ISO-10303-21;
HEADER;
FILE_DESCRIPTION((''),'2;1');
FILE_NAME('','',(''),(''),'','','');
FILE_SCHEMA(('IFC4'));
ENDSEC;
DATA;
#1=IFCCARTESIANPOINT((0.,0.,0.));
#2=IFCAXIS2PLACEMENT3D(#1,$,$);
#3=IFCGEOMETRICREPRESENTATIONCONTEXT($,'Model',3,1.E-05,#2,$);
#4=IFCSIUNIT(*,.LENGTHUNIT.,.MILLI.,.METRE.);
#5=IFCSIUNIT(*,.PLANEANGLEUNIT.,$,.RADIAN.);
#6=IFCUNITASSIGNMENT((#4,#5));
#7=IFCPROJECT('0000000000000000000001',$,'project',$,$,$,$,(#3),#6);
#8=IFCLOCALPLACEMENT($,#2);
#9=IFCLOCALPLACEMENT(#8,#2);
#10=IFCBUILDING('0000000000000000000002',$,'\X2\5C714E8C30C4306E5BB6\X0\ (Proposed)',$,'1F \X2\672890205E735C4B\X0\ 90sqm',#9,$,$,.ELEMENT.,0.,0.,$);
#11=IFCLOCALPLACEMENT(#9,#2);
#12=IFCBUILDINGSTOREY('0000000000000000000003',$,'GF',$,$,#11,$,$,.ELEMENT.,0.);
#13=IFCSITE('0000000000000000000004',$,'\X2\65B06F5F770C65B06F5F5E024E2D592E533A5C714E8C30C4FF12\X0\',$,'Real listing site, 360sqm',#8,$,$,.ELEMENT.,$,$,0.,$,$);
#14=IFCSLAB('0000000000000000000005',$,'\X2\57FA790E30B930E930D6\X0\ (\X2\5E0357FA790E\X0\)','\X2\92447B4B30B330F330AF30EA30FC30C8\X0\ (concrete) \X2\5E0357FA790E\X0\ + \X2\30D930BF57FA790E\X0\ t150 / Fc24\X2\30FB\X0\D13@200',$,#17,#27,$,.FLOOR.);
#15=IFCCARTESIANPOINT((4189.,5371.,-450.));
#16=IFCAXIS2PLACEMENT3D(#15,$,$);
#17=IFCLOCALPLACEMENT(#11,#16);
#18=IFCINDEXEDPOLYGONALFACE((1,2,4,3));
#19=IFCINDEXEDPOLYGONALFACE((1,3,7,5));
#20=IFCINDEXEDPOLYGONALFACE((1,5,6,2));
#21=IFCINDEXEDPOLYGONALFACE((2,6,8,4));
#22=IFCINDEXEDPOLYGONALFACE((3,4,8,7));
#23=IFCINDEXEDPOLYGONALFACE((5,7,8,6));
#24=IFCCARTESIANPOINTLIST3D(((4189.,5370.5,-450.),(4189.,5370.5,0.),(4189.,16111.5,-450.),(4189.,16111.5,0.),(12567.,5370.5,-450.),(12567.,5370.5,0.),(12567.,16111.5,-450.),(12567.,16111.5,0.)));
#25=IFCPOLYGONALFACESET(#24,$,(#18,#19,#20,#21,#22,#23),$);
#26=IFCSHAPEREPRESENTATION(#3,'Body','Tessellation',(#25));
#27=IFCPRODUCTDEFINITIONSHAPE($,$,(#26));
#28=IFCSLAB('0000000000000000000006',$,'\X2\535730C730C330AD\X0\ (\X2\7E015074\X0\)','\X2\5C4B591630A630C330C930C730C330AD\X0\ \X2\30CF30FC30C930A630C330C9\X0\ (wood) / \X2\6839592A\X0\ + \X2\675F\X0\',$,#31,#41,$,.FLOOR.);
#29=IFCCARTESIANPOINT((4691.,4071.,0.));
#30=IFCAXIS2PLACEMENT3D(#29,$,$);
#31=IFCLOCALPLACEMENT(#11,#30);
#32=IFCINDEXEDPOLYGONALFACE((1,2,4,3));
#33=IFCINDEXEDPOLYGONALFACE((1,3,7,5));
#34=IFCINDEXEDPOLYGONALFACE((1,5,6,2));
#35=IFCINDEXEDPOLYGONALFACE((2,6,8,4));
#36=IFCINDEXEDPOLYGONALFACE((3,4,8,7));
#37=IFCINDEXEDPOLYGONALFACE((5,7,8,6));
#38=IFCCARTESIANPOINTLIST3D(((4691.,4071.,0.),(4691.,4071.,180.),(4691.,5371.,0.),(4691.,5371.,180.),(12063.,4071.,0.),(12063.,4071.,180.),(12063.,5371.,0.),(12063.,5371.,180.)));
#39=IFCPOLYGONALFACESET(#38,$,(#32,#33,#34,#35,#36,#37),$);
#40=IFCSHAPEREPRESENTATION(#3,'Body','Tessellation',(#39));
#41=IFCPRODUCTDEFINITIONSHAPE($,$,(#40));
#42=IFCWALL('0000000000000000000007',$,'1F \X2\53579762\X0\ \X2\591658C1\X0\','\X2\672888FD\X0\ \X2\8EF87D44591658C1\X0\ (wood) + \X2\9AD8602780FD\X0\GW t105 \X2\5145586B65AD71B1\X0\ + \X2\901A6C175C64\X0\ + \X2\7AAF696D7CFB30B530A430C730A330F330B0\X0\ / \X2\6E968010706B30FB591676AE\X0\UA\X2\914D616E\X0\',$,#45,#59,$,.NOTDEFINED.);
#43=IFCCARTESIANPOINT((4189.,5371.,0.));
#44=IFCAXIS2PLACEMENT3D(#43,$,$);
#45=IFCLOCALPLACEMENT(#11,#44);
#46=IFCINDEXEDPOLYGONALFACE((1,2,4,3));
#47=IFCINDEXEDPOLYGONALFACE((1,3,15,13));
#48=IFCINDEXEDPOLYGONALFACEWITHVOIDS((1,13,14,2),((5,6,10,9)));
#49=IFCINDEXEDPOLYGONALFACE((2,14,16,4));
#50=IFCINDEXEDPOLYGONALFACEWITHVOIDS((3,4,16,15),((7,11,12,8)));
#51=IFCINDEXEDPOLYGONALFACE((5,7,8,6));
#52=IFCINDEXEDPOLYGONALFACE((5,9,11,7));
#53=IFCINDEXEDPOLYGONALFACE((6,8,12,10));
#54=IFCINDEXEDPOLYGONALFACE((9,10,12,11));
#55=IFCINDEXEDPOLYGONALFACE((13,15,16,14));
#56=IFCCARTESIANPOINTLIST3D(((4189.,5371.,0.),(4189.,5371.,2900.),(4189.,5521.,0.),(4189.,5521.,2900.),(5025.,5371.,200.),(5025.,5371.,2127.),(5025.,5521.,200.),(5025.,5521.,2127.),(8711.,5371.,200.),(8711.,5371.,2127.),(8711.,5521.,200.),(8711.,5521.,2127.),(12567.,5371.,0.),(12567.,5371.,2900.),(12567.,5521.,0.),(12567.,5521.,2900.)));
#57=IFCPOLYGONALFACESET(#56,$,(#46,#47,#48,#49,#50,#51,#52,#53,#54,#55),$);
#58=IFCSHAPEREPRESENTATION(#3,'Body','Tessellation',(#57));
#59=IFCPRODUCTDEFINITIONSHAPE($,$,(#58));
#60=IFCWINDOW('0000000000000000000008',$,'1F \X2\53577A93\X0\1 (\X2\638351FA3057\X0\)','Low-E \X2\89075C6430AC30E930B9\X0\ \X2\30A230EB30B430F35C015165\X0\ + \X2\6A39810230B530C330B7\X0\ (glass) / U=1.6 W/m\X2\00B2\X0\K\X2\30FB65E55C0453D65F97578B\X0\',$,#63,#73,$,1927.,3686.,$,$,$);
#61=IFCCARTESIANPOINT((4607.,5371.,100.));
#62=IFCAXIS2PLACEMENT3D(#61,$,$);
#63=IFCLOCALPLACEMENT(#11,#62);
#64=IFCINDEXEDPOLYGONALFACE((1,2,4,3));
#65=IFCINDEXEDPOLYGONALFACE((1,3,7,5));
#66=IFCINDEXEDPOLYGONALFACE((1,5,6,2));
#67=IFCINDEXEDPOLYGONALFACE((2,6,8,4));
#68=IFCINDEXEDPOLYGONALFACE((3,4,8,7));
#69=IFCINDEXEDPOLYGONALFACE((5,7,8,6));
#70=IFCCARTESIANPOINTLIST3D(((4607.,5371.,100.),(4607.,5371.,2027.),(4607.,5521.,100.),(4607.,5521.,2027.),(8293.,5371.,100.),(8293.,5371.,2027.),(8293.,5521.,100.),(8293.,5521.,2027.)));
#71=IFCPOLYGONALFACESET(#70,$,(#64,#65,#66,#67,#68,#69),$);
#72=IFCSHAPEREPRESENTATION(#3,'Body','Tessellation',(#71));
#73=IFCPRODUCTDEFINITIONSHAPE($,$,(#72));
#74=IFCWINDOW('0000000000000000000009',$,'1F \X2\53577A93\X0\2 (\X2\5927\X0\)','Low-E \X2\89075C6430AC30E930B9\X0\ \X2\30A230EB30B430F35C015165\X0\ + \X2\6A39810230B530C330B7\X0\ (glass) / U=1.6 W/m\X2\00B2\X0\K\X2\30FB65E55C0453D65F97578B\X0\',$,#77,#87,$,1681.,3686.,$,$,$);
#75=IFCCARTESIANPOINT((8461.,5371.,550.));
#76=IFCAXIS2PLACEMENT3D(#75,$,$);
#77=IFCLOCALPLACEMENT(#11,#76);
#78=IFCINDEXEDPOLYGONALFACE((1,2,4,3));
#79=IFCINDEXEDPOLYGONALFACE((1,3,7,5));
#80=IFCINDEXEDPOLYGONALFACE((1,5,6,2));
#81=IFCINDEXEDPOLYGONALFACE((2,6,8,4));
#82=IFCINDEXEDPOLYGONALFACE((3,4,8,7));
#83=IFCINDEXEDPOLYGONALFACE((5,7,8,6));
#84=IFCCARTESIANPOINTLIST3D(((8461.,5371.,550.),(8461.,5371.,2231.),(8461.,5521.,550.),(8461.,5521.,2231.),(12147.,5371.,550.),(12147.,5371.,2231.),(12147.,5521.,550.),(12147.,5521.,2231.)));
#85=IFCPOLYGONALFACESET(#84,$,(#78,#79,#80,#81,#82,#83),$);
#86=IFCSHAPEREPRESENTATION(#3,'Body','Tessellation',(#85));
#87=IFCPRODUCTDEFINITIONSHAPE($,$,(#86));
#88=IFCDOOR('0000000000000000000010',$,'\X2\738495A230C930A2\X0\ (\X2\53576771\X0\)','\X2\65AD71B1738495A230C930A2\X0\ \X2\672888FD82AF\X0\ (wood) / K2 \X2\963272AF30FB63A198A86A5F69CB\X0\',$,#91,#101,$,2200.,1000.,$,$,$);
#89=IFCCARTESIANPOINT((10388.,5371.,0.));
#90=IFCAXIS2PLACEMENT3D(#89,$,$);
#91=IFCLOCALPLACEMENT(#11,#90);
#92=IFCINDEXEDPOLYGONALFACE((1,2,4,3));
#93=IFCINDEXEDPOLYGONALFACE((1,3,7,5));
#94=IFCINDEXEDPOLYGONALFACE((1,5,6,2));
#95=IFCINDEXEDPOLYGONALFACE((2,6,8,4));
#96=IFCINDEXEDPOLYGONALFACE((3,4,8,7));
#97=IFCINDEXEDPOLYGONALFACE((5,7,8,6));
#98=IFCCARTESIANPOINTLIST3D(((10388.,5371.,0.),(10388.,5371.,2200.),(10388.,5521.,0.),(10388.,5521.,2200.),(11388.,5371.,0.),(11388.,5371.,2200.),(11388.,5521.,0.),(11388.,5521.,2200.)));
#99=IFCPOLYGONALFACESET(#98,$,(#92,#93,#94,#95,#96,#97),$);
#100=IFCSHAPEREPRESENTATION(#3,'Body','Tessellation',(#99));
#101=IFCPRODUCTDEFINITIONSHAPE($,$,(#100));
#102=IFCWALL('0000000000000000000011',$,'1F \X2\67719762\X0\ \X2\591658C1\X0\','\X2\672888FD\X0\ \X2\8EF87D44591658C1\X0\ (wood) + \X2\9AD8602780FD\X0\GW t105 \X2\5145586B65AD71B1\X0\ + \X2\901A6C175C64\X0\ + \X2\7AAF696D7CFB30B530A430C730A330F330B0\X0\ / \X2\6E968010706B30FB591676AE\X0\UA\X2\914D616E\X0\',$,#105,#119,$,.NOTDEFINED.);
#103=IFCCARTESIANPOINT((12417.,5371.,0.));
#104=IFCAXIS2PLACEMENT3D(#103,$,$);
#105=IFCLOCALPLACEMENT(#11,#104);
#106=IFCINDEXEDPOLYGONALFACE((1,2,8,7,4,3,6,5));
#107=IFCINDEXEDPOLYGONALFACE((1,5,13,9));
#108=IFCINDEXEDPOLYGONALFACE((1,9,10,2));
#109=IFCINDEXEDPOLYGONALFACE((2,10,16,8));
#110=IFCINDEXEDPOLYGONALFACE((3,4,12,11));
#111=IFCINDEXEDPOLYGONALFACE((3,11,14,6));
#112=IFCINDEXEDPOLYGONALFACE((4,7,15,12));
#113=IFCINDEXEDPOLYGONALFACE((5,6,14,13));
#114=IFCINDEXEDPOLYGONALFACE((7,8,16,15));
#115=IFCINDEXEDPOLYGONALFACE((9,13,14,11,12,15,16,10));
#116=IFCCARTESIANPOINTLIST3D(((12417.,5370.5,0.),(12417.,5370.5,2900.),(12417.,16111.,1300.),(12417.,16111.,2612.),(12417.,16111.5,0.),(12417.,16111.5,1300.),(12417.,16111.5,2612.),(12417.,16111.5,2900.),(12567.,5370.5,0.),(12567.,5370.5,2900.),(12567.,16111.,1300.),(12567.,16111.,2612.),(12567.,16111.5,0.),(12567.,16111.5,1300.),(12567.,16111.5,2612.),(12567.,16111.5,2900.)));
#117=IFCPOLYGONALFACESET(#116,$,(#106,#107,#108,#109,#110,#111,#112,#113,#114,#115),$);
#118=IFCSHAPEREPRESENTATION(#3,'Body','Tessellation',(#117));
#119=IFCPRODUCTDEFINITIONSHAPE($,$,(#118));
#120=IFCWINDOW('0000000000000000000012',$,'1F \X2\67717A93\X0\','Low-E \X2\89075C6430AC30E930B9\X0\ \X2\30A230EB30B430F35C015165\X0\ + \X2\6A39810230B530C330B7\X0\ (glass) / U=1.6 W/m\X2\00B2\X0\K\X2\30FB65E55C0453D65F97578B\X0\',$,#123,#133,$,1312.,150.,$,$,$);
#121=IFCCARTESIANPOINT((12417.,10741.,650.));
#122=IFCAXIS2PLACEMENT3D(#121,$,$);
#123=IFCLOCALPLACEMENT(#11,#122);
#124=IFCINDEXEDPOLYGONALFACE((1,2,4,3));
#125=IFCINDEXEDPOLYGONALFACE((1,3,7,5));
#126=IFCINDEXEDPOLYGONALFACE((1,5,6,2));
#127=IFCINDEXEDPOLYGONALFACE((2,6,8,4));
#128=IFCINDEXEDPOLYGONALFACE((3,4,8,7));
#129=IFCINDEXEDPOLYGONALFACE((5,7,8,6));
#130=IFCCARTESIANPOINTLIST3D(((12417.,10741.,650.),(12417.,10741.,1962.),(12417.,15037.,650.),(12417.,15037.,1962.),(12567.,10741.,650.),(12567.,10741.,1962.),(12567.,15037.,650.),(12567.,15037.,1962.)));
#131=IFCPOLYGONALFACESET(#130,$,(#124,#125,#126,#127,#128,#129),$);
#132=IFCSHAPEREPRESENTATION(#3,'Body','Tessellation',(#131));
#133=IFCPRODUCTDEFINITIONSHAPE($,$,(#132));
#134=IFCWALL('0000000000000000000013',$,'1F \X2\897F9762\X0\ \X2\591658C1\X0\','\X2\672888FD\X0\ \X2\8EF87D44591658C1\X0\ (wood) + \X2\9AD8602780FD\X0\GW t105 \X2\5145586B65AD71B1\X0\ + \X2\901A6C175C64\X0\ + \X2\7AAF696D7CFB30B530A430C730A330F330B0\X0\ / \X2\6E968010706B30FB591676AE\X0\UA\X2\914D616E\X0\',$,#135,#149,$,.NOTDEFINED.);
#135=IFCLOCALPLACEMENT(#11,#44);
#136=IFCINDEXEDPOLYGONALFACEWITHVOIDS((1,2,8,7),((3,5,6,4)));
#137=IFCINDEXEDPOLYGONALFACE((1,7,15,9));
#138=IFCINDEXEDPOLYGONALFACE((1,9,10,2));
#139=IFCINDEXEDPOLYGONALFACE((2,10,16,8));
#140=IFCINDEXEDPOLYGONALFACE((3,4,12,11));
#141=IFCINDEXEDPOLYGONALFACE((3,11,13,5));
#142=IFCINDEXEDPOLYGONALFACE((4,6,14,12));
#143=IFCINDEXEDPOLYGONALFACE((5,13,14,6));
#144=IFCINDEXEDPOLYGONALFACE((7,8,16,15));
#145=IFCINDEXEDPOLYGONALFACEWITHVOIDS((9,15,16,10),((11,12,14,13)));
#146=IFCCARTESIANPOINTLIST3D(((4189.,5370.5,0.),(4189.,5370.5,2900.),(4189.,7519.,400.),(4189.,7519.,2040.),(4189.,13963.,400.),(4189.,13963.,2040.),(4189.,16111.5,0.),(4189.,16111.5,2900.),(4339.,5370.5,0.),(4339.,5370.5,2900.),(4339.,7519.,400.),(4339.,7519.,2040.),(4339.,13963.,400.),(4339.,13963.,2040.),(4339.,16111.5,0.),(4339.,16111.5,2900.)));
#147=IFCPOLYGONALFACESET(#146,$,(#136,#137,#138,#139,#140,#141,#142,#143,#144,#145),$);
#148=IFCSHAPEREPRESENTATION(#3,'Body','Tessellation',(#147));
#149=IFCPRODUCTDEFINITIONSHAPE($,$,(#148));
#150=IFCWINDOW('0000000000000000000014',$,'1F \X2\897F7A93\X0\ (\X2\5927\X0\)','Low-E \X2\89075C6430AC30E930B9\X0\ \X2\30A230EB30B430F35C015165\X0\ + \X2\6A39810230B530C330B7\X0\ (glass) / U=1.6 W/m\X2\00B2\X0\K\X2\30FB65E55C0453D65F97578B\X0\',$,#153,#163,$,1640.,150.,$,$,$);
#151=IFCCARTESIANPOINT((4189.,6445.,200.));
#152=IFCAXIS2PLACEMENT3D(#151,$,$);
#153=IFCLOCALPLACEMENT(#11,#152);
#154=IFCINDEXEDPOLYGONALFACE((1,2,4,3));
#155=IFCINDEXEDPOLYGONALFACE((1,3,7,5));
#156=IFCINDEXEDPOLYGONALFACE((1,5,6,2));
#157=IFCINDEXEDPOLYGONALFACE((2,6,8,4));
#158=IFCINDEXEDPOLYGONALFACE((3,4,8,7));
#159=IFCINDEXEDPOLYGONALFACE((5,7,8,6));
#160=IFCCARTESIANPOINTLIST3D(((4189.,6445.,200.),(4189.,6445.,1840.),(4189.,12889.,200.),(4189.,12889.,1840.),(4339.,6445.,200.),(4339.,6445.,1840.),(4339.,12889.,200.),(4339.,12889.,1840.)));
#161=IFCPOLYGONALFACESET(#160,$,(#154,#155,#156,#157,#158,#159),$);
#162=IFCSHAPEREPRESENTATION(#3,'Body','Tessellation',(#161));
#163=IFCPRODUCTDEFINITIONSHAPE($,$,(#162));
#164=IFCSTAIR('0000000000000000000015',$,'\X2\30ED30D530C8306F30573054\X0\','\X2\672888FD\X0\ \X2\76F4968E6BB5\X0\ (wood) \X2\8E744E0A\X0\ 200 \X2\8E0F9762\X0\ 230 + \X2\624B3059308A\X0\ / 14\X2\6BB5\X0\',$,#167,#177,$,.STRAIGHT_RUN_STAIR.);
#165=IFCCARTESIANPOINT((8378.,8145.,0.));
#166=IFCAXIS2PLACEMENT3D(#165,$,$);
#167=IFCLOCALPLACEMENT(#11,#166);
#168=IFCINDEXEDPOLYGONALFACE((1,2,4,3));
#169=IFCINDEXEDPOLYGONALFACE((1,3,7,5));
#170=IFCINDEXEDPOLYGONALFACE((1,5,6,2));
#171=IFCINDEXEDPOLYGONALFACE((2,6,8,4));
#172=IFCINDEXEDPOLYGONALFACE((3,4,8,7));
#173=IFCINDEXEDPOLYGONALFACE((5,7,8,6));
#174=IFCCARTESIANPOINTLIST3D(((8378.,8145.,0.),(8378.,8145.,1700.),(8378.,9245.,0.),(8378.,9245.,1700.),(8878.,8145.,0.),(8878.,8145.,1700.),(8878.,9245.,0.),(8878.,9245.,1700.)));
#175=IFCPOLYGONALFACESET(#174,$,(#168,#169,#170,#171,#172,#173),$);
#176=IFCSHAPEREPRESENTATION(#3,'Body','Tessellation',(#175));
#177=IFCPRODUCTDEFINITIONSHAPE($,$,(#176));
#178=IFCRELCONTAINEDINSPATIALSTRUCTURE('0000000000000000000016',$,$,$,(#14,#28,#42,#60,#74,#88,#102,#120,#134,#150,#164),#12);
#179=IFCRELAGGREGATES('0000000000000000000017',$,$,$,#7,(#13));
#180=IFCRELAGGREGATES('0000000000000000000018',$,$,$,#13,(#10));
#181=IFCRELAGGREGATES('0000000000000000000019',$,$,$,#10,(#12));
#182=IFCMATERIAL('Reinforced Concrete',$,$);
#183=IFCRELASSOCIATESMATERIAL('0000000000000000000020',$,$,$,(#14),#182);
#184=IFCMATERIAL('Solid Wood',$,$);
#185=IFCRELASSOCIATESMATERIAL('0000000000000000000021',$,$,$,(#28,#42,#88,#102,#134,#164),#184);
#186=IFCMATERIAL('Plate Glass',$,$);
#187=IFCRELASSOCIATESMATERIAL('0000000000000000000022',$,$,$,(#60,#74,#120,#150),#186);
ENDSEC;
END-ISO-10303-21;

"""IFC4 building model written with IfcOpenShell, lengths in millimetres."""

from ifc_helpers import new_model, si_unit, frame, frame_2d, origin, place, context, project, spatial, rectangle, extrude, material, element, fill, save


model = new_model("IFC4")

# Units and contexts
model_context = context("Model", 3, precision=1e-05, world=origin())
ifc_project = project(units=[si_unit("LENGTHUNIT", "METRE", prefix="MILLI"), si_unit("PLANEANGLEUNIT", "RADIAN")], contexts=[model_context])

# Site, building, storey
site_placement = place(None, origin())
site = spatial("IfcSite", under=ifc_project, at=site_placement, Name="新潟県新潟市中央区山二ツ２", ObjectType="Real listing site, 360sqm", CompositionType="ELEMENT", RefElevation=0.0)
building_placement = place(site_placement, origin())
building = spatial("IfcBuilding", under=site, at=building_placement, Name="山二ツの家 (Proposed)", ObjectType="1F 木造平屋 90sqm", CompositionType="ELEMENT", ElevationOfRefHeight=0.0, ElevationOfTerrain=0.0)
storey_placement = place(building_placement, origin())
storey = spatial("IfcBuildingStorey", under=building, at=storey_placement, Name="GF", CompositionType="ELEMENT", Elevation=0.0)

# Slabs
ifc_material_1 = material(Name="Reinforced Concrete")
slab_1_placement = place(storey_placement, frame((4189.0, 5371.0, -450.0)))
element("IfcSlab", 1, at=slab_1_placement, inside=storey, material=ifc_material_1, Name="基礎スラブ (布基礎)", Description="鉄筋コンクリート (concrete) 布基礎 + ベタ基礎 t150 / Fc24・D13@200", PredefinedType="FLOOR", context=model_context, shape_type="SweptSolid", body=[
    extrude(rectangle(XDim=8378.0, YDim=10741.0, at=frame_2d((4189.0, 5370.0))), frame((4189.0, 5371.0, -450.0)), (0.0, 0.0, 1.0), 450.0),
])
ifc_material_2 = material(Name="Solid Wood")
slab_2_placement = place(storey_placement, frame((4691.0, 4071.0, 0.0)))
element("IfcSlab", 2, at=slab_2_placement, inside=storey, material=ifc_material_2, Name="南デッキ (縁側)", Description="屋外ウッドデッキ ハードウッド (wood) / 根太 + 束", PredefinedType="FLOOR", context=model_context, shape_type="SweptSolid", body=[
    extrude(rectangle(XDim=7372.0, YDim=1300.0, at=frame_2d((3686.0, 650.0))), frame((4691.0, 4071.0, 0.0)), (0.0, 0.0, 1.0), 180.0),
])

# Wall, openings, windows, door
wall_1_placement = place(storey_placement, frame((4189.0, 5371.0, 0.0)))
wall_1 = element("IfcWall", 3, at=wall_1_placement, inside=storey, material=ifc_material_2, Name="1F 南面 外壁", Description="木製 軸組外壁 (wood) + 高性能GW t105 充填断熱 + 通気層 + 窯業系サイディング / 準耐火・外皮UA配慮", PredefinedType="NOTDEFINED", context=model_context, shape_type="SweptSolid", body=[
    extrude(rectangle(XDim=8378.0, YDim=150.0, at=frame_2d((4189.0, 75.0))), frame((4189.0, 5371.0, 0.0)), (0.0, 0.0, 1.0), 2900.0),
])
opening_1_placement = place(storey_placement, frame((4607.0, 5371.0, 100.0)))
opening_1 = element("IfcOpeningElement", 4, at=opening_1_placement, cuts=wall_1, PredefinedType="NOTDEFINED", context=model_context, shape_type="SweptSolid", body=[
    extrude(rectangle(XDim=3686.0, YDim=150.0, at=frame_2d((1843.0, 75.0))), frame((4607.0, 5371.0, 100.0)), (0.0, 0.0, 1.0), 1927.0),
])
opening_2_placement = place(storey_placement, frame((8461.0, 5371.0, 550.0)))
opening_2 = element("IfcOpeningElement", 5, at=opening_2_placement, cuts=wall_1, PredefinedType="NOTDEFINED", context=model_context, shape_type="SweptSolid", body=[
    extrude(rectangle(XDim=3686.0, YDim=150.0, at=frame_2d((1843.0, 75.0))), frame((8461.0, 5371.0, 550.0)), (0.0, 0.0, 1.0), 1681.0),
])
opening_3_placement = place(storey_placement, frame((10388.0, 5371.0, 0.0)))
opening_3 = element("IfcOpeningElement", 6, at=opening_3_placement, cuts=wall_1, PredefinedType="NOTDEFINED", context=model_context, shape_type="SweptSolid", body=[
    extrude(rectangle(XDim=1000.0, YDim=150.0, at=frame_2d((500.0, 75.0))), frame((10388.0, 5371.0, 0.0)), (0.0, 0.0, 1.0), 2200.0),
])
ifc_material_3 = material(Name="Plate Glass")
window_1_placement = place(storey_placement, frame((4607.0, 5371.0, 100.0)))
window_1 = element("IfcWindow", 7, at=window_1_placement, inside=storey, material=ifc_material_3, Name="1F 南窓1 (掃出し)", Description="Low-E 複層ガラス アルゴン封入 + 樹脂サッシ (glass) / U=1.6 W/m²K・日射取得型", OverallHeight=1927.0, OverallWidth=3686.0, context=model_context, shape_type="SweptSolid", body=[
    extrude(rectangle(XDim=3686.0, YDim=150.0, at=frame_2d((1843.0, 75.0))), frame((4607.0, 5371.0, 100.0)), (0.0, 0.0, 1.0), 1927.0),
])
fill(opening_1, window_1)
window_2_placement = place(storey_placement, frame((8461.0, 5371.0, 550.0)))
window_2 = element("IfcWindow", 8, at=window_2_placement, inside=storey, material=ifc_material_3, Name="1F 南窓2 (大)", Description="Low-E 複層ガラス アルゴン封入 + 樹脂サッシ (glass) / U=1.6 W/m²K・日射取得型", OverallHeight=1681.0, OverallWidth=3686.0, context=model_context, shape_type="SweptSolid", body=[
    extrude(rectangle(XDim=3686.0, YDim=150.0, at=frame_2d((1843.0, 75.0))), frame((8461.0, 5371.0, 550.0)), (0.0, 0.0, 1.0), 1681.0),
])
fill(opening_2, window_2)
door_placement = place(storey_placement, frame((10388.0, 5371.0, 0.0)))
door = element("IfcDoor", 9, at=door_placement, inside=storey, material=ifc_material_2, Name="玄関ドア (南東)", Description="断熱玄関ドア 木製芯 (wood) / K2 防犯・採風機構", OverallHeight=2200.0, OverallWidth=1000.0, context=model_context, shape_type="SweptSolid", body=[
    extrude(rectangle(XDim=1000.0, YDim=150.0, at=frame_2d((500.0, 75.0))), frame((10388.0, 5371.0, 0.0)), (0.0, 0.0, 1.0), 2200.0),
])
fill(opening_3, door)

# Walls, openings, windows
wall_2_placement = place(storey_placement, frame((12417.0, 5371.0, 0.0)))
wall_2 = element("IfcWall", 10, at=wall_2_placement, inside=storey, material=ifc_material_2, Name="1F 東面 外壁", Description="木製 軸組外壁 (wood) + 高性能GW t105 充填断熱 + 通気層 + 窯業系サイディング / 準耐火・外皮UA配慮", PredefinedType="NOTDEFINED", context=model_context, shape_type="SweptSolid", body=[
    extrude(rectangle(XDim=150.0, YDim=10741.0, at=frame_2d((75.0, 5370.0))), frame((12417.0, 5371.0, 0.0)), (0.0, 0.0, 1.0), 2900.0),
])
opening_4_placement = place(storey_placement, frame((12417.0, 10741.0, 650.0)))
opening_4 = element("IfcOpeningElement", 11, at=opening_4_placement, cuts=wall_2, PredefinedType="NOTDEFINED", context=model_context, shape_type="SweptSolid", body=[
    extrude(rectangle(XDim=150.0, YDim=4296.0, at=frame_2d((75.0, 2148.0))), frame((12417.0, 10741.0, 650.0)), (0.0, 0.0, 1.0), 1312.0),
])
window_3_placement = place(storey_placement, frame((12417.0, 10741.0, 650.0)))
window_3 = element("IfcWindow", 12, at=window_3_placement, inside=storey, material=ifc_material_3, Name="1F 東窓", Description="Low-E 複層ガラス アルゴン封入 + 樹脂サッシ (glass) / U=1.6 W/m²K・日射取得型", OverallHeight=1312.0, OverallWidth=150.0, context=model_context, shape_type="SweptSolid", body=[
    extrude(rectangle(XDim=150.0, YDim=4296.0, at=frame_2d((75.0, 2148.0))), frame((12417.0, 10741.0, 650.0)), (0.0, 0.0, 1.0), 1312.0),
])
fill(opening_4, window_3)
wall_3_placement = place(storey_placement, frame((4189.0, 5371.0, 0.0)))
wall_3 = element("IfcWall", 13, at=wall_3_placement, inside=storey, material=ifc_material_2, Name="1F 西面 外壁", Description="木製 軸組外壁 (wood) + 高性能GW t105 充填断熱 + 通気層 + 窯業系サイディング / 準耐火・外皮UA配慮", PredefinedType="NOTDEFINED", context=model_context, shape_type="SweptSolid", body=[
    extrude(rectangle(XDim=150.0, YDim=10741.0, at=frame_2d((75.0, 5370.0))), frame((4189.0, 5371.0, 0.0)), (0.0, 0.0, 1.0), 2900.0),
])
opening_5_placement = place(storey_placement, frame((4189.0, 6445.0, 200.0)))
opening_5 = element("IfcOpeningElement", 14, at=opening_5_placement, cuts=wall_3, PredefinedType="NOTDEFINED", context=model_context, shape_type="SweptSolid", body=[
    extrude(rectangle(XDim=150.0, YDim=6444.0, at=frame_2d((75.0, 3222.0))), frame((4189.0, 6445.0, 200.0)), (0.0, 0.0, 1.0), 1640.0),
])
window_4_placement = place(storey_placement, frame((4189.0, 6445.0, 200.0)))
window_4 = element("IfcWindow", 15, at=window_4_placement, inside=storey, material=ifc_material_3, Name="1F 西窓 (大)", Description="Low-E 複層ガラス アルゴン封入 + 樹脂サッシ (glass) / U=1.6 W/m²K・日射取得型", OverallHeight=1640.0, OverallWidth=150.0, context=model_context, shape_type="SweptSolid", body=[
    extrude(rectangle(XDim=150.0, YDim=6444.0, at=frame_2d((75.0, 3222.0))), frame((4189.0, 6445.0, 200.0)), (0.0, 0.0, 1.0), 1640.0),
])
fill(opening_5, window_4)

# Stair
stair_placement = place(storey_placement, frame((8378.0, 8145.0, 0.0)))
element("IfcStair", 16, at=stair_placement, inside=storey, material=ifc_material_2, Name="ロフトはしご", Description="木製 直階段 (wood) 蹴上 200 踏面 230 + 手すり / 14段", PredefinedType="STRAIGHT_RUN_STAIR", context=model_context, shape_type="SweptSolid", body=[
    extrude(rectangle(XDim=500.0, YDim=1100.0, at=frame_2d((250.0, 550.0))), frame((8378.0, 8145.0, 0.0)), (0.0, 0.0, 1.0), 1700.0),
])

save(model, "model.ifc")
